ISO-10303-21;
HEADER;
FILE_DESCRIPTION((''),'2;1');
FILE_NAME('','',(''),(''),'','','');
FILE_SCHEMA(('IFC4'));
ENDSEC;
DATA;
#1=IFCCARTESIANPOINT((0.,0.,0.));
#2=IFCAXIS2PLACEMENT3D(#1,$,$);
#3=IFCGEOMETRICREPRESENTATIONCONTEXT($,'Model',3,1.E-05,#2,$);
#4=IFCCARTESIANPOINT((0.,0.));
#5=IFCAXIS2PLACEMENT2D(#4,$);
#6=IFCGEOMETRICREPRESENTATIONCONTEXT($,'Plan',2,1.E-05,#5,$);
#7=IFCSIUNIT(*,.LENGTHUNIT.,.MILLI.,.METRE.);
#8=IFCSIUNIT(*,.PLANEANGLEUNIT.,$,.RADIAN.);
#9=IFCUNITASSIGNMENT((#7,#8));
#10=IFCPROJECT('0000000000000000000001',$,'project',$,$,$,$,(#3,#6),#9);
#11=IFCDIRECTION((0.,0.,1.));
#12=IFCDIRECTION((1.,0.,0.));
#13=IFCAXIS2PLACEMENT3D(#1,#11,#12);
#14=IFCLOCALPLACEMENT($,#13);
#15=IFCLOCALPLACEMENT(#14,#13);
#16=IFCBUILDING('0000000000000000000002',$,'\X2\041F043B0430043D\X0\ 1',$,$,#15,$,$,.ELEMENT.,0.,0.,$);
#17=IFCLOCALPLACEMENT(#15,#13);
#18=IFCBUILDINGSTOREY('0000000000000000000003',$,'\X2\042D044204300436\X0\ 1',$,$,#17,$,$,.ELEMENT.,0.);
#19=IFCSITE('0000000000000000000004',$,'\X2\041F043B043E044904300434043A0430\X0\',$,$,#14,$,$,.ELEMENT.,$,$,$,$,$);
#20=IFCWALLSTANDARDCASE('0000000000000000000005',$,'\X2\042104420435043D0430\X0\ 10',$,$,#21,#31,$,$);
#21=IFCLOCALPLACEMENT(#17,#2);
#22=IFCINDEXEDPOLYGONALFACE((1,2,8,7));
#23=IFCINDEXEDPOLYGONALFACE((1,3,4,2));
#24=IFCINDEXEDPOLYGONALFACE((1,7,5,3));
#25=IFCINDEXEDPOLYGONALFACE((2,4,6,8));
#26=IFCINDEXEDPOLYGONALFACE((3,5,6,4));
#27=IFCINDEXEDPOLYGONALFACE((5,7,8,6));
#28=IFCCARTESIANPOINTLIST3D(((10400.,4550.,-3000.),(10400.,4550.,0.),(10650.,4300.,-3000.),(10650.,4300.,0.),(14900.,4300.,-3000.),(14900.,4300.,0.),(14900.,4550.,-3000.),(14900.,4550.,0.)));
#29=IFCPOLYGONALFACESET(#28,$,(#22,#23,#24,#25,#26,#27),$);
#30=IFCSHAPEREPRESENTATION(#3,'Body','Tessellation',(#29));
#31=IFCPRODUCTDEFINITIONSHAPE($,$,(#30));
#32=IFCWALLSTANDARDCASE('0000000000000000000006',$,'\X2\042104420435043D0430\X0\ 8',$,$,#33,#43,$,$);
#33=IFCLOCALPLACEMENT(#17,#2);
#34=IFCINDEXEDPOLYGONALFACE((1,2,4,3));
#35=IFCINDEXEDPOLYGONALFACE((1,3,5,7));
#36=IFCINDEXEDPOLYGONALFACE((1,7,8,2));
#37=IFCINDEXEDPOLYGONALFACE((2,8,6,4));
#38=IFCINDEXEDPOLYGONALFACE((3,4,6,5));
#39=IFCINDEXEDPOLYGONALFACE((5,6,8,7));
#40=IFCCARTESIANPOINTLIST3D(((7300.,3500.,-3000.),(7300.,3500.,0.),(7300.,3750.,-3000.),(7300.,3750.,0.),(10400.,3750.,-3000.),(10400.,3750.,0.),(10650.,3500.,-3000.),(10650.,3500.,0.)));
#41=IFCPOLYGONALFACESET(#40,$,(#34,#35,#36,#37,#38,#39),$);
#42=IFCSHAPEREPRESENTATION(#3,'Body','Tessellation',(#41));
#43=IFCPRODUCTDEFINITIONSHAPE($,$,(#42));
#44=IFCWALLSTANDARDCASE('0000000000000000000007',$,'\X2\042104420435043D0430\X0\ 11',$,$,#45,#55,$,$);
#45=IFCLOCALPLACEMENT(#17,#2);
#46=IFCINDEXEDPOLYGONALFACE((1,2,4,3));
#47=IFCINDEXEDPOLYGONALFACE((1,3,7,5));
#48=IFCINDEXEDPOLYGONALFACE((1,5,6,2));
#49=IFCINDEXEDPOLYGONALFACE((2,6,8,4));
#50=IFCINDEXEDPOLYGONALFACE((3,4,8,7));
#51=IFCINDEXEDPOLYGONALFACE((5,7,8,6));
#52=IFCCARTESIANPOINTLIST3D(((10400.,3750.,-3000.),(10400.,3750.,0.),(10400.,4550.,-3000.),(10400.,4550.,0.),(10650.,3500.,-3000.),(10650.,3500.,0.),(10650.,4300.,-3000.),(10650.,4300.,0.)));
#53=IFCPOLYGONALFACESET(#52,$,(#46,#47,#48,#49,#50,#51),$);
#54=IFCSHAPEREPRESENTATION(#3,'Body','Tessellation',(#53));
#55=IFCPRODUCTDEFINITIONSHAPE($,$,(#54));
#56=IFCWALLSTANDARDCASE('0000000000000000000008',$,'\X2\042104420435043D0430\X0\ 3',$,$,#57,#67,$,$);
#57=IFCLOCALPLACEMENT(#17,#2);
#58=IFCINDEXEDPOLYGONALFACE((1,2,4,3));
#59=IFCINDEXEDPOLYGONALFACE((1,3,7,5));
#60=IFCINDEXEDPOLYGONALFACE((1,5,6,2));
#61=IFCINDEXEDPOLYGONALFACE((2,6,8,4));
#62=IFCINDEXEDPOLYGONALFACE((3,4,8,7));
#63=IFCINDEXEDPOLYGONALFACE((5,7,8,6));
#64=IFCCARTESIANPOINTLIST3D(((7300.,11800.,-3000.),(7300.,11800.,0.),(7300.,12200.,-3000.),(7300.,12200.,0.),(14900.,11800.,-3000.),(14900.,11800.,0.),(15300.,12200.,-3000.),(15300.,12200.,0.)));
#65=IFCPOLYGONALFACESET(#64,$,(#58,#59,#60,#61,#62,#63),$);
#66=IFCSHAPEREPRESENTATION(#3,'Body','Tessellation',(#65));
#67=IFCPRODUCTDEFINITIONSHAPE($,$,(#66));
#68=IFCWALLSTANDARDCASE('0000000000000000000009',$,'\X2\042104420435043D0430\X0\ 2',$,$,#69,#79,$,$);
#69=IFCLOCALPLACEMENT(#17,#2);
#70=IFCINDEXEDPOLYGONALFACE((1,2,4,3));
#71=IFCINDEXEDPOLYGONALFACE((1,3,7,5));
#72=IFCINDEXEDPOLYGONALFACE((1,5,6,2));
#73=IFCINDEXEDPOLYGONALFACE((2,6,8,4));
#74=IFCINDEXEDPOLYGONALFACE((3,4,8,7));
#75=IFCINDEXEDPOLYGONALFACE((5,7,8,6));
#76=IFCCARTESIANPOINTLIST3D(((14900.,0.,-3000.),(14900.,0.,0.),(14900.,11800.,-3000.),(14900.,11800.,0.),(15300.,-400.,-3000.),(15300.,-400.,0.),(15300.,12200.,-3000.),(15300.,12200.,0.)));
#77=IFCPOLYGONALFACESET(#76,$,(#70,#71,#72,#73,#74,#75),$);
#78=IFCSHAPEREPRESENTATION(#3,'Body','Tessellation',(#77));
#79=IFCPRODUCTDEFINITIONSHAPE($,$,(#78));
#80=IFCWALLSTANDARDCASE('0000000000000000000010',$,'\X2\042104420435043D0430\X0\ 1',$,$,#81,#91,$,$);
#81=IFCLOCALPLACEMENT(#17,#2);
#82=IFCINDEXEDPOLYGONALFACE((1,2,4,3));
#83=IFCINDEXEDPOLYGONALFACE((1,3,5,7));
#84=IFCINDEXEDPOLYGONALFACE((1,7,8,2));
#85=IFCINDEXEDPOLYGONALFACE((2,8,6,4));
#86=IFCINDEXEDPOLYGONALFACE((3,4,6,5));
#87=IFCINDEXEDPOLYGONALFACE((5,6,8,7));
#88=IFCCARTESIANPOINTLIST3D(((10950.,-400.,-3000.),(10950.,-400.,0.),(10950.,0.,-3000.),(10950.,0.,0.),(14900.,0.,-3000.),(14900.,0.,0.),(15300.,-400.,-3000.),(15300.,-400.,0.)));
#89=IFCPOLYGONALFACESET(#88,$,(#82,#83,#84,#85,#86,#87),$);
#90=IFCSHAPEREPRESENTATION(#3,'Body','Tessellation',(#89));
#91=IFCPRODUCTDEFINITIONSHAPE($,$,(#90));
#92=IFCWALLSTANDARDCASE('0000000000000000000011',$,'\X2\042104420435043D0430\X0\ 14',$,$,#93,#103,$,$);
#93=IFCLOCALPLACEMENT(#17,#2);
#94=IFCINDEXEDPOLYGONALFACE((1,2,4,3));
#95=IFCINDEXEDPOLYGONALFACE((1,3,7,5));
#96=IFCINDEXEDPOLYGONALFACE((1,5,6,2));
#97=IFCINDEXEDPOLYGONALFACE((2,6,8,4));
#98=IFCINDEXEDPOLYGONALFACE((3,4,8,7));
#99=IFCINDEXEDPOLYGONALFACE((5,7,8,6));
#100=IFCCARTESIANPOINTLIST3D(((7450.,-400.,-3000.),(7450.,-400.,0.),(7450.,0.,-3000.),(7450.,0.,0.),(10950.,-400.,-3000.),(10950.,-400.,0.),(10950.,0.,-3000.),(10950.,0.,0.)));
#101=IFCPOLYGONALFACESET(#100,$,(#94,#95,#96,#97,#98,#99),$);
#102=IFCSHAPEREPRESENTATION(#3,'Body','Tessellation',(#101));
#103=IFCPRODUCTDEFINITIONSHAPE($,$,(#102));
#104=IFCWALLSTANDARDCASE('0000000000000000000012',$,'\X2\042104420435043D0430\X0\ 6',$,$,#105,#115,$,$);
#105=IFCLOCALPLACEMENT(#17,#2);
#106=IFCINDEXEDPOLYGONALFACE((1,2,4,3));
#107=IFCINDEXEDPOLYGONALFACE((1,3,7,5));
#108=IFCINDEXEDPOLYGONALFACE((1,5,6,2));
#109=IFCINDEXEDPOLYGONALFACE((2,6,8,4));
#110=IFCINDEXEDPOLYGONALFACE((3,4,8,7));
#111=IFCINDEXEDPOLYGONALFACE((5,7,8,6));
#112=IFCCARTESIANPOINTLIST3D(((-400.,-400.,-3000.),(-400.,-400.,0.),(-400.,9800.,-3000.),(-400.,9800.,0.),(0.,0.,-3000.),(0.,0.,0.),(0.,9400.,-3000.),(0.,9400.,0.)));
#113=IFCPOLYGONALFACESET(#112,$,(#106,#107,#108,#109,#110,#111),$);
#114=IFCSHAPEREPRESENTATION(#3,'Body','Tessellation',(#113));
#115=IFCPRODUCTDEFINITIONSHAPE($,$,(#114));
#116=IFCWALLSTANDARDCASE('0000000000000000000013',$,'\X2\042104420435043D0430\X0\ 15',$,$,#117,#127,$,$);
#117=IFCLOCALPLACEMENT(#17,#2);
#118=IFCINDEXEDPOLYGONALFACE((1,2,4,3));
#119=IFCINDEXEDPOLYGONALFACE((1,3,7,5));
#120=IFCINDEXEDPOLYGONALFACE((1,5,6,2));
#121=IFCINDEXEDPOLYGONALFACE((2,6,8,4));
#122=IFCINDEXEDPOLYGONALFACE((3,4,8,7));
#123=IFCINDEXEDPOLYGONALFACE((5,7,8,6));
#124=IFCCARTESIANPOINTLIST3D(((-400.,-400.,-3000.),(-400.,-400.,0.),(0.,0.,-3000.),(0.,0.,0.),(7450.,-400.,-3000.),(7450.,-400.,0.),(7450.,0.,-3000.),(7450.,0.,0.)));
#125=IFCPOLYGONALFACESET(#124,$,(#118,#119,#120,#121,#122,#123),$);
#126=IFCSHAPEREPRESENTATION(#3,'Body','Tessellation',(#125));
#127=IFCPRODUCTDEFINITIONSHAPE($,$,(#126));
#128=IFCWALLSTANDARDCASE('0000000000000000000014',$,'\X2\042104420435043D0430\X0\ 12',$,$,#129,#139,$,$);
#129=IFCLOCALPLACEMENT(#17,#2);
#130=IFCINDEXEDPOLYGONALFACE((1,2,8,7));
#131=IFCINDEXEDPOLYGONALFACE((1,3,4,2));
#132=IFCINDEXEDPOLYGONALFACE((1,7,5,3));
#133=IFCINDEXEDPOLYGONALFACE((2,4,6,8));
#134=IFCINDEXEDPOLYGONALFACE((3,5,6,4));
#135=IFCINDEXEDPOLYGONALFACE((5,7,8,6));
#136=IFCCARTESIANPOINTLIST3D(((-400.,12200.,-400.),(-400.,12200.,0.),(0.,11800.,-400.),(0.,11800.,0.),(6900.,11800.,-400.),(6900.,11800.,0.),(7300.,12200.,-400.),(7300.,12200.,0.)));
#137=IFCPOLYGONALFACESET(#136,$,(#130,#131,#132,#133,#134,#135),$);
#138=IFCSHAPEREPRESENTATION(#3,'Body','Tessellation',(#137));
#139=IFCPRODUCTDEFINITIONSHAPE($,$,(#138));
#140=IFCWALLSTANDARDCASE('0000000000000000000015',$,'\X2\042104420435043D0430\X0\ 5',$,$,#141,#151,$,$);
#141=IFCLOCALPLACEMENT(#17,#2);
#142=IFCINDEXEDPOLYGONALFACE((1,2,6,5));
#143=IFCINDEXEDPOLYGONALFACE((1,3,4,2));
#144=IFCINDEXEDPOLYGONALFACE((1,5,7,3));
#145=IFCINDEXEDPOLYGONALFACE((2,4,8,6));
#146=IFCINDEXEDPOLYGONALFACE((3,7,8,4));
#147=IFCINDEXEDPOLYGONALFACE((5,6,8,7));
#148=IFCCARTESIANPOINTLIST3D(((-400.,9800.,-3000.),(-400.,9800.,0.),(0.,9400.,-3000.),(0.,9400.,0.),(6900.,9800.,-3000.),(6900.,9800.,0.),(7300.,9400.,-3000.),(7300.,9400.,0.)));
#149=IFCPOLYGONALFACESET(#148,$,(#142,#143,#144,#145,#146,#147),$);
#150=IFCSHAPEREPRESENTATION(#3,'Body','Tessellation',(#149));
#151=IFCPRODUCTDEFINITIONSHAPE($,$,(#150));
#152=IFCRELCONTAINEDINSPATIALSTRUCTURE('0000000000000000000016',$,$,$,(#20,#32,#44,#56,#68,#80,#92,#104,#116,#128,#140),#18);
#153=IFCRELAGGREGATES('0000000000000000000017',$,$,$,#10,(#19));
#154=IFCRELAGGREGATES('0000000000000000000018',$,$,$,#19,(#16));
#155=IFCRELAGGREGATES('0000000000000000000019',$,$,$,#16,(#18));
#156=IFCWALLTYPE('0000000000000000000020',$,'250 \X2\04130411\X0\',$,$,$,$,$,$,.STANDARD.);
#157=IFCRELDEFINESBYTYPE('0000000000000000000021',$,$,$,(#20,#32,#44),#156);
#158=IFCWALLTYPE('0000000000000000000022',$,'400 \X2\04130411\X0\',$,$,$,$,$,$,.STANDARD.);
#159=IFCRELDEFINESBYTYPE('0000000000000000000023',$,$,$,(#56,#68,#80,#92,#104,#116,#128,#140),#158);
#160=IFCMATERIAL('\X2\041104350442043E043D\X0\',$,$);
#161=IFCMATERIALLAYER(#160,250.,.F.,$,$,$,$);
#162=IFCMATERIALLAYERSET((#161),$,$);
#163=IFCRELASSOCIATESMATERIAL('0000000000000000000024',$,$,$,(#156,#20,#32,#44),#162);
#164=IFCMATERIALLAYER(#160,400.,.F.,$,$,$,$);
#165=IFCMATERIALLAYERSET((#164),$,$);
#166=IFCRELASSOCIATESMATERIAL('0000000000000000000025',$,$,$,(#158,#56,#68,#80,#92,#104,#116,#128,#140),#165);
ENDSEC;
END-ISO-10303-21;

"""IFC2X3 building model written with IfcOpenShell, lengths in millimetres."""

from ifc_helpers import new_model, si_unit, frame, origin, origin_with_axes, origin_2d, place, context, project, spatial, polyline, segment, composite_curve, outline, extrude, material, layer, layer_set, layer_usage, type_object, element, save


model = new_model("IFC2X3")

# Units and contexts
model_context = context("Model", 3, precision=1e-05, world=origin())
plan_context = context("Plan", 2, precision=1e-05, world=origin_2d())
ifc_project = project(units=[si_unit("LENGTHUNIT", "METRE", prefix="MILLI"), si_unit("PLANEANGLEUNIT", "RADIAN")], contexts=[model_context, plan_context])

# Site, building, storey
site_placement = place(None, origin_with_axes())
site = spatial("IfcSite", under=ifc_project, at=site_placement, Name="Площадка", CompositionType="ELEMENT")
building_placement = place(site_placement, origin_with_axes())
building = spatial("IfcBuilding", under=site, at=building_placement, Name="План 1", CompositionType="ELEMENT", ElevationOfRefHeight=0.0, ElevationOfTerrain=0.0)
storey_placement = place(building_placement, origin_with_axes())
storey = spatial("IfcBuildingStorey", under=building, at=storey_placement, Name="Этаж 1", CompositionType="ELEMENT", Elevation=0.0)

# Walls
ifc_material = material(Name="Бетон")
ifc_layer_1 = layer(ifc_material, 250.0, ventilated=False)
ifc_layer_set_1 = layer_set([ifc_layer_1])
wall_type_1 = type_object("IfcWallType", Name="250 ГБ", PredefinedType="STANDARD", material=ifc_layer_set_1)
ifc_layer_usage_1 = layer_usage(ifc_layer_set_1, "AXIS2", "POSITIVE", -250.0)
wall_1_placement = place(storey_placement, frame((10400.0, 4550.0, -3000.0), z_axis=(0.0, 0.0, 1.0), x_axis=(1.0, 0.0, 0.0)))
element("IfcWallStandardCase", 1, at=wall_1_placement, inside=storey, type_object=wall_type_1, material=ifc_layer_usage_1, Name="Стена 10", context=model_context, shape_type="SweptSolid", body=[
    extrude(outline(composite_curve([segment(polyline([(0.0, 0.0), (250.0, -250.0)]), True, "CONTINUOUS"), segment(polyline([(250.0, -250.0), (4500.0, -250.0)]), True, "CONTINUOUS"), segment(polyline([(4500.0, -250.0), (4500.0, 0.0)]), True, "CONTINUOUS"), segment(polyline([(4500.0, 0.0), (0.0, 0.0)]), True, "CONTINUOUS")], self_intersect=False)), origin_with_axes(), (0.0, 0.0, 1.0), 3000.0),
])
ifc_layer_usage_2 = layer_usage(ifc_layer_set_1, "AXIS2", "POSITIVE", -250.0)
wall_2_placement = place(storey_placement, frame((7050.0, 3750.0, -3000.0), z_axis=(0.0, 0.0, 1.0), x_axis=(1.0, 0.0, 0.0)))
element("IfcWallStandardCase", 2, at=wall_2_placement, inside=storey, type_object=wall_type_1, material=ifc_layer_usage_2, Name="Стена 8", context=model_context, shape_type="SweptSolid", body=[
    extrude(outline(composite_curve([segment(polyline([(250.0, 0.0), (250.0, -250.0)]), True, "CONTINUOUS"), segment(polyline([(250.0, -250.0), (3600.0, -250.0)]), True, "CONTINUOUS"), segment(polyline([(3600.0, -250.0), (3350.0, 0.0)]), True, "CONTINUOUS"), segment(polyline([(3350.0, 0.0), (250.0, 0.0)]), True, "CONTINUOUS")], self_intersect=False)), origin_with_axes(), (0.0, 0.0, 1.0), 3000.0),
])
ifc_layer_usage_3 = layer_usage(ifc_layer_set_1, "AXIS2", "POSITIVE", -250.0)
wall_3_placement = place(storey_placement, frame((10400.0, 3750.0, -3000.0), z_axis=(0.0, 0.0, 1.0), x_axis=(0.0, 1.0, 0.0)))
element("IfcWallStandardCase", 3, at=wall_3_placement, inside=storey, type_object=wall_type_1, material=ifc_layer_usage_3, Name="Стена 11", context=model_context, shape_type="SweptSolid", body=[
    extrude(outline(composite_curve([segment(polyline([(0.0, 0.0), (-250.0, -250.0)]), True, "CONTINUOUS"), segment(polyline([(-250.0, -250.0), (550.0, -250.0)]), True, "CONTINUOUS"), segment(polyline([(550.0, -250.0), (800.0, 0.0)]), True, "CONTINUOUS"), segment(polyline([(800.0, 0.0), (0.0, 0.0)]), True, "CONTINUOUS")], self_intersect=False)), origin_with_axes(), (0.0, 0.0, 1.0), 3000.0),
])
ifc_layer_2 = layer(ifc_material, 400.0, ventilated=False)
ifc_layer_set_2 = layer_set([ifc_layer_2])
ifc_layer_usage_4 = layer_usage(ifc_layer_set_2, "AXIS2", "POSITIVE", 0.0)
wall_type_2 = type_object("IfcWallType", Name="400 ГБ", PredefinedType="STANDARD", material=ifc_layer_set_2)
wall_4_placement = place(storey_placement, frame((15300.0, 12200.0, -3000.0), z_axis=(0.0, 0.0, 1.0), x_axis=(-1.0, 0.0, 0.0)))
element("IfcWallStandardCase", 4, at=wall_4_placement, inside=storey, type_object=wall_type_2, material=ifc_layer_usage_4, Name="Стена 3", context=model_context, shape_type="SweptSolid", body=[
    extrude(outline(composite_curve([segment(polyline([(400.0, 400.0), (0.0, 0.0)]), True, "CONTINUOUS"), segment(polyline([(0.0, 0.0), (8000.0, 0.0)]), True, "CONTINUOUS"), segment(polyline([(8000.0, 0.0), (8000.0, 400.0)]), True, "CONTINUOUS"), segment(polyline([(8000.0, 400.0), (400.0, 400.0)]), True, "CONTINUOUS")], self_intersect=False)), origin_with_axes(), (0.0, 0.0, 1.0), 3000.0),
])
ifc_layer_usage_5 = layer_usage(ifc_layer_set_2, "AXIS2", "POSITIVE", 0.0)
wall_5_placement = place(storey_placement, frame((15300.0, -400.0, -3000.0), z_axis=(0.0, 0.0, 1.0), x_axis=(0.0, 1.0, 0.0)))
element("IfcWallStandardCase", 5, at=wall_5_placement, inside=storey, type_object=wall_type_2, material=ifc_layer_usage_5, Name="Стена 2", context=model_context, shape_type="SweptSolid", body=[
    extrude(outline(composite_curve([segment(polyline([(400.0, 400.0), (0.0, 0.0)]), True, "CONTINUOUS"), segment(polyline([(0.0, 0.0), (12600.0, 0.0)]), True, "CONTINUOUS"), segment(polyline([(12600.0, 0.0), (12200.0, 400.0)]), True, "CONTINUOUS"), segment(polyline([(12200.0, 400.0), (400.0, 400.0)]), True, "CONTINUOUS")], self_intersect=False)), origin_with_axes(), (0.0, 0.0, 1.0), 3000.0),
])
ifc_layer_usage_6 = layer_usage(ifc_layer_set_2, "AXIS2", "POSITIVE", 0.0)
wall_6_placement = place(storey_placement, frame((10950.0, -400.0, -3000.0), z_axis=(0.0, 0.0, 1.0), x_axis=(1.0, 0.0, 0.0)))
element("IfcWallStandardCase", 6, at=wall_6_placement, inside=storey, type_object=wall_type_2, material=ifc_layer_usage_6, Name="Стена 1", context=model_context, shape_type="SweptSolid", body=[
    extrude(outline(composite_curve([segment(polyline([(0.0, 400.0), (0.0, 0.0)]), True, "CONTINUOUS"), segment(polyline([(0.0, 0.0), (4350.0, 0.0)]), True, "CONTINUOUS"), segment(polyline([(4350.0, 0.0), (3950.0, 400.0)]), True, "CONTINUOUS"), segment(polyline([(3950.0, 400.0), (0.0, 400.0)]), True, "CONTINUOUS")], self_intersect=False)), origin_with_axes(), (0.0, 0.0, 1.0), 3000.0),
])
ifc_layer_usage_7 = layer_usage(ifc_layer_set_2, "AXIS2", "POSITIVE", 0.0)
wall_7_placement = place(storey_placement, frame((7450.0, -400.0, -3000.0), z_axis=(0.0, 0.0, 1.0), x_axis=(1.0, 0.0, 0.0)))
element("IfcWallStandardCase", 7, at=wall_7_placement, inside=storey, type_object=wall_type_2, material=ifc_layer_usage_7, Name="Стена 14", context=model_context, shape_type="SweptSolid", body=[
    extrude(outline(composite_curve([segment(polyline([(0.0, 400.0), (0.0, 0.0)]), True, "CONTINUOUS"), segment(polyline([(0.0, 0.0), (3500.0, 0.0)]), True, "CONTINUOUS"), segment(polyline([(3500.0, 0.0), (3500.0, 400.0)]), True, "CONTINUOUS"), segment(polyline([(3500.0, 400.0), (0.0, 400.0)]), True, "CONTINUOUS")], self_intersect=False)), origin_with_axes(), (0.0, 0.0, 1.0), 3000.0),
])
ifc_layer_usage_8 = layer_usage(ifc_layer_set_2, "AXIS2", "POSITIVE", 0.0)
wall_8_placement = place(storey_placement, frame((-400.0, 9800.0, -3000.0), z_axis=(0.0, 0.0, 1.0), x_axis=(0.0, -1.0, 0.0)))
element("IfcWallStandardCase", 8, at=wall_8_placement, inside=storey, type_object=wall_type_2, material=ifc_layer_usage_8, Name="Стена 6", context=model_context, shape_type="SweptSolid", body=[
    extrude(outline(composite_curve([segment(polyline([(400.0, 400.0), (0.0, 0.0)]), True, "CONTINUOUS"), segment(polyline([(0.0, 0.0), (10200.0, 0.0)]), True, "CONTINUOUS"), segment(polyline([(10200.0, 0.0), (9800.0, 400.0)]), True, "CONTINUOUS"), segment(polyline([(9800.0, 400.0), (400.0, 400.0)]), True, "CONTINUOUS")], self_intersect=False)), origin_with_axes(), (0.0, 0.0, 1.0), 3000.0),
])
ifc_layer_usage_9 = layer_usage(ifc_layer_set_2, "AXIS2", "POSITIVE", 0.0)
wall_9_placement = place(storey_placement, frame((-400.0, -400.0, -3000.0), z_axis=(0.0, 0.0, 1.0), x_axis=(1.0, 0.0, 0.0)))
element("IfcWallStandardCase", 9, at=wall_9_placement, inside=storey, type_object=wall_type_2, material=ifc_layer_usage_9, Name="Стена 15", context=model_context, shape_type="SweptSolid", body=[
    extrude(outline(composite_curve([segment(polyline([(400.0, 400.0), (0.0, 0.0)]), True, "CONTINUOUS"), segment(polyline([(0.0, 0.0), (7850.0, 0.0)]), True, "CONTINUOUS"), segment(polyline([(7850.0, 0.0), (7850.0, 400.0)]), True, "CONTINUOUS"), segment(polyline([(7850.0, 400.0), (400.0, 400.0)]), True, "CONTINUOUS")], self_intersect=False)), origin_with_axes(), (0.0, 0.0, 1.0), 3000.0),
])
ifc_layer_usage_10 = layer_usage(ifc_layer_set_2, "AXIS2", "POSITIVE", 0.0)
wall_10_placement = place(storey_placement, frame((6900.0, 12200.0, -400.0), z_axis=(0.0, 0.0, 1.0), x_axis=(-1.0, 0.0, 0.0)))
element("IfcWallStandardCase", 10, at=wall_10_placement, inside=storey, type_object=wall_type_2, material=ifc_layer_usage_10, Name="Стена 12", context=model_context, shape_type="SweptSolid", body=[
    extrude(outline(composite_curve([segment(polyline([(0.0, 400.0), (-400.0, 0.0)]), True, "CONTINUOUS"), segment(polyline([(-400.0, 0.0), (7300.0, 0.0)]), True, "CONTINUOUS"), segment(polyline([(7300.0, 0.0), (6900.0, 400.0)]), True, "CONTINUOUS"), segment(polyline([(6900.0, 400.0), (0.0, 400.0)]), True, "CONTINUOUS")], self_intersect=False)), origin_with_axes(), (0.0, 0.0, 1.0), 400.0),
])
ifc_layer_usage_11 = layer_usage(ifc_layer_set_2, "AXIS2", "POSITIVE", 0.0)
wall_11_placement = place(storey_placement, frame((6900.0, 9800.0, -3000.0), z_axis=(0.0, 0.0, 1.0), x_axis=(-1.0, 0.0, 0.0)))
element("IfcWallStandardCase", 11, at=wall_11_placement, inside=storey, type_object=wall_type_2, material=ifc_layer_usage_11, Name="Стена 5", context=model_context, shape_type="SweptSolid", body=[
    extrude(outline(composite_curve([segment(polyline([(-400.0, 400.0), (0.0, 0.0)]), True, "CONTINUOUS"), segment(polyline([(0.0, 0.0), (7300.0, 0.0)]), True, "CONTINUOUS"), segment(polyline([(7300.0, 0.0), (6900.0, 400.0)]), True, "CONTINUOUS"), segment(polyline([(6900.0, 400.0), (-400.0, 400.0)]), True, "CONTINUOUS")], self_intersect=False)), origin_with_axes(), (0.0, 0.0, 1.0), 3000.0),
])

save(model, "model.ifc")
